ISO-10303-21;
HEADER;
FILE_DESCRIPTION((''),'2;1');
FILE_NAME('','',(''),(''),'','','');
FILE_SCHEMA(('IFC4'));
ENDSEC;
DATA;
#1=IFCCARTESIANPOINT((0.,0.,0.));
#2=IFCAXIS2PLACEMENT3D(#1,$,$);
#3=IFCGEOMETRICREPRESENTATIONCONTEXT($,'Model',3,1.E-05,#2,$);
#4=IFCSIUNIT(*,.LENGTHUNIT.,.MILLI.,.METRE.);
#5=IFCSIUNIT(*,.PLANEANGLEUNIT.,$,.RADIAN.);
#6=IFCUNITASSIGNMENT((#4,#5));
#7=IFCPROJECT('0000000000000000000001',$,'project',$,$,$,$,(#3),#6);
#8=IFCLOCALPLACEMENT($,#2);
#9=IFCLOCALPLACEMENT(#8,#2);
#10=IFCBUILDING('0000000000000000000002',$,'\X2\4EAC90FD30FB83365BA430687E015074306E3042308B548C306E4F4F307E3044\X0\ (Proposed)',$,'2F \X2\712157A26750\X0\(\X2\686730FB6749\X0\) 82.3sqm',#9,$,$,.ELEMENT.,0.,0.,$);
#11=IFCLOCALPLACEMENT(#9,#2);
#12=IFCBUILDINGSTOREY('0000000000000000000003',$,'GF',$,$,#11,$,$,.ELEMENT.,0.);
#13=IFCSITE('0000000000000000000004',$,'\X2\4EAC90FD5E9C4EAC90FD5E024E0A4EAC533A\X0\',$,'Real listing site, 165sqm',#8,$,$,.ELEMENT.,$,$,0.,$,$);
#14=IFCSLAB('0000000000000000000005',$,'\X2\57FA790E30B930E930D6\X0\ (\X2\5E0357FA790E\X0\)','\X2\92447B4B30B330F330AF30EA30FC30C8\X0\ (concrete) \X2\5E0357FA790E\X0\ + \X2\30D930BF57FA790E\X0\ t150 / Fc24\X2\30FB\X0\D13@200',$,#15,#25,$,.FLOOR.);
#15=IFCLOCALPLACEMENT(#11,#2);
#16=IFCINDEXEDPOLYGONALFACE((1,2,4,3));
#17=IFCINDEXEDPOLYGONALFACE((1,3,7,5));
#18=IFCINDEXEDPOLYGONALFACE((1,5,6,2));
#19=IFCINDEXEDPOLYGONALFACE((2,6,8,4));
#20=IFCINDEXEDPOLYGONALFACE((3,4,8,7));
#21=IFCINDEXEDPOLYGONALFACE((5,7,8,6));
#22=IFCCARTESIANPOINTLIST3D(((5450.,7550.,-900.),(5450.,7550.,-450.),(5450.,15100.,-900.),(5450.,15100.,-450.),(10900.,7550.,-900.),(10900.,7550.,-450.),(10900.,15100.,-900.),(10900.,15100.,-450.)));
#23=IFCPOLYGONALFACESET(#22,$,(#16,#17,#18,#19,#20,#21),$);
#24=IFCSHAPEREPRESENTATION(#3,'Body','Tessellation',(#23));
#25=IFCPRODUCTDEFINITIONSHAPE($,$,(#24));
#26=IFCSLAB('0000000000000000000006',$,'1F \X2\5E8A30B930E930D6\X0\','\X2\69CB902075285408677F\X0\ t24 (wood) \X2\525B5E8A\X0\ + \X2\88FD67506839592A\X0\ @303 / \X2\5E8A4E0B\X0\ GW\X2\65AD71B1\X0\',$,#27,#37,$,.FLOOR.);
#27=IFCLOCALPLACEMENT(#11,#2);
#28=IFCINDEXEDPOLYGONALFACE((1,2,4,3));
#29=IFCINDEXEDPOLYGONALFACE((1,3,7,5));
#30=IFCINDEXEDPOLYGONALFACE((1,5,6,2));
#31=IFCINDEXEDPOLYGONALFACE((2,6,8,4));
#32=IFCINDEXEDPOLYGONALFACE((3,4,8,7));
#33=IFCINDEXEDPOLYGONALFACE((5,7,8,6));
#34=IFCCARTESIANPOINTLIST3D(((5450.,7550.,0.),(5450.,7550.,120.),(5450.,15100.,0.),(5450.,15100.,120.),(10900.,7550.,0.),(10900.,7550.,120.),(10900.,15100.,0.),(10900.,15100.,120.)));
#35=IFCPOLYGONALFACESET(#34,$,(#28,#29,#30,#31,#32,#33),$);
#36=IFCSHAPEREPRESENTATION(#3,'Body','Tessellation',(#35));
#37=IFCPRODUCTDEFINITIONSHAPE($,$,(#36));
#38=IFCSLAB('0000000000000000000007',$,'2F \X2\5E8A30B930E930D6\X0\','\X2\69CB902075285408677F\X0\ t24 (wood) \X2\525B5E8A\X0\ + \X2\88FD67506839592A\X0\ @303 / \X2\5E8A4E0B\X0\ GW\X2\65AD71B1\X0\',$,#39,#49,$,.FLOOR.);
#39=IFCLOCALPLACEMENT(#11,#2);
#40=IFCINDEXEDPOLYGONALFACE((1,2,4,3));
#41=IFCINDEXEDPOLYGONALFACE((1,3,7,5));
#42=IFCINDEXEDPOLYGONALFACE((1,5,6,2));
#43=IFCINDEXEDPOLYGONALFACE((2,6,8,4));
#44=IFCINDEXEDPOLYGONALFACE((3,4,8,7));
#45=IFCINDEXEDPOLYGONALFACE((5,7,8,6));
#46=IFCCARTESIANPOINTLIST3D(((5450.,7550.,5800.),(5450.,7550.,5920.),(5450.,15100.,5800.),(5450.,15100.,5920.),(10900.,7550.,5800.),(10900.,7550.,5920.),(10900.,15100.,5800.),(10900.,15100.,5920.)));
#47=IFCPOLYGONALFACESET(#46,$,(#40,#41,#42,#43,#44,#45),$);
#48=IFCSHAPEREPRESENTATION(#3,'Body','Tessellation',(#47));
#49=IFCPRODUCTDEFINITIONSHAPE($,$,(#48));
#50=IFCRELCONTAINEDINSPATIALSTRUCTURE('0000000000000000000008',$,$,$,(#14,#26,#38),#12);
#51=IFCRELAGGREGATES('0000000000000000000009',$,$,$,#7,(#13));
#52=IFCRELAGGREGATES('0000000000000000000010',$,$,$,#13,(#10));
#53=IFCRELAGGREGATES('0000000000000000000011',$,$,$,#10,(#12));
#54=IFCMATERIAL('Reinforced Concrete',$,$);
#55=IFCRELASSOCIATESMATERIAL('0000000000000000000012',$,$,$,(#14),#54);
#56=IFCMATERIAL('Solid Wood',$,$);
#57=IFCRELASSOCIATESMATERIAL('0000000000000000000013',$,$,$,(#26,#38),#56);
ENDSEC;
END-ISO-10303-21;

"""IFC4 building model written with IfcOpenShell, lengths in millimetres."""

from ifc_helpers import new_model, si_unit, frame, frame_2d, origin, place, context, project, spatial, rectangle, extrude, material, element, save


model = new_model("IFC4")

# Units and contexts
model_context = context("Model", 3, precision=1e-05, world=origin())
ifc_project = project(units=[si_unit("LENGTHUNIT", "METRE", prefix="MILLI"), si_unit("PLANEANGLEUNIT", "RADIAN")], contexts=[model_context])

# Site, building, storey
site_placement = place(None, origin())
site = spatial("IfcSite", under=ifc_project, at=site_placement, Name="京都府京都市上京区", ObjectType="Real listing site, 165sqm", CompositionType="ELEMENT", RefElevation=0.0)
building_placement = place(site_placement, origin())
building = spatial("IfcBuilding", under=site, at=building_placement, Name="京都・茶室と縁側のある和の住まい (Proposed)", ObjectType="2F 無垢材(桧・杉) 82.3sqm", CompositionType="ELEMENT", ElevationOfRefHeight=0.0, ElevationOfTerrain=0.0)
storey_placement = place(building_placement, origin())
storey = spatial("IfcBuildingStorey", under=building, at=storey_placement, Name="GF", CompositionType="ELEMENT", Elevation=0.0)

# Shared definitions
ifc_material_1 = material(Name="Solid Wood")

# Slabs
ifc_material_2 = material(Name="Reinforced Concrete")
slab_1_placement = place(storey_placement, frame((2725.0, 3775.0, -450.0)))
element("IfcSlab", 1, at=slab_1_placement, inside=storey, material=ifc_material_2, Name="基礎スラブ (布基礎)", Description="鉄筋コンクリート (concrete) 布基礎 + ベタ基礎 t150 / Fc24・D13@200", PredefinedType="FLOOR", context=model_context, shape_type="SweptSolid", body=[
    extrude(rectangle(XDim=5450.0, YDim=7550.0, at=frame_2d((2725.0, 3775.0))), frame((2725.0, 3775.0, -450.0)), (0.0, 0.0, 1.0), 450.0),
])
slab_2_placement = place(storey_placement, frame((2725.0, 3775.0, 0.0)))
element("IfcSlab", 2, at=slab_2_placement, inside=storey, material=ifc_material_1, Name="1F 床スラブ", Description="構造用合板 t24 (wood) 剛床 + 製材根太 @303 / 床下 GW断熱", PredefinedType="FLOOR", context=model_context, shape_type="SweptSolid", body=[
    extrude(rectangle(XDim=5450.0, YDim=7550.0, at=frame_2d((2725.0, 3775.0))), frame((2725.0, 3775.0, 0.0)), (0.0, 0.0, 1.0), 120.0),
])
slab_3_placement = place(storey_placement, frame((2725.0, 3775.0, 2900.0)))
element("IfcSlab", 3, at=slab_3_placement, inside=storey, material=ifc_material_1, Name="2F 床スラブ", Description="構造用合板 t24 (wood) 剛床 + 製材根太 @303 / 床下 GW断熱", PredefinedType="FLOOR", context=model_context, shape_type="SweptSolid", body=[
    extrude(rectangle(XDim=5450.0, YDim=7550.0, at=frame_2d((2725.0, 3775.0))), frame((2725.0, 3775.0, 2900.0)), (0.0, 0.0, 1.0), 120.0),
])

save(model, "model.ifc")
